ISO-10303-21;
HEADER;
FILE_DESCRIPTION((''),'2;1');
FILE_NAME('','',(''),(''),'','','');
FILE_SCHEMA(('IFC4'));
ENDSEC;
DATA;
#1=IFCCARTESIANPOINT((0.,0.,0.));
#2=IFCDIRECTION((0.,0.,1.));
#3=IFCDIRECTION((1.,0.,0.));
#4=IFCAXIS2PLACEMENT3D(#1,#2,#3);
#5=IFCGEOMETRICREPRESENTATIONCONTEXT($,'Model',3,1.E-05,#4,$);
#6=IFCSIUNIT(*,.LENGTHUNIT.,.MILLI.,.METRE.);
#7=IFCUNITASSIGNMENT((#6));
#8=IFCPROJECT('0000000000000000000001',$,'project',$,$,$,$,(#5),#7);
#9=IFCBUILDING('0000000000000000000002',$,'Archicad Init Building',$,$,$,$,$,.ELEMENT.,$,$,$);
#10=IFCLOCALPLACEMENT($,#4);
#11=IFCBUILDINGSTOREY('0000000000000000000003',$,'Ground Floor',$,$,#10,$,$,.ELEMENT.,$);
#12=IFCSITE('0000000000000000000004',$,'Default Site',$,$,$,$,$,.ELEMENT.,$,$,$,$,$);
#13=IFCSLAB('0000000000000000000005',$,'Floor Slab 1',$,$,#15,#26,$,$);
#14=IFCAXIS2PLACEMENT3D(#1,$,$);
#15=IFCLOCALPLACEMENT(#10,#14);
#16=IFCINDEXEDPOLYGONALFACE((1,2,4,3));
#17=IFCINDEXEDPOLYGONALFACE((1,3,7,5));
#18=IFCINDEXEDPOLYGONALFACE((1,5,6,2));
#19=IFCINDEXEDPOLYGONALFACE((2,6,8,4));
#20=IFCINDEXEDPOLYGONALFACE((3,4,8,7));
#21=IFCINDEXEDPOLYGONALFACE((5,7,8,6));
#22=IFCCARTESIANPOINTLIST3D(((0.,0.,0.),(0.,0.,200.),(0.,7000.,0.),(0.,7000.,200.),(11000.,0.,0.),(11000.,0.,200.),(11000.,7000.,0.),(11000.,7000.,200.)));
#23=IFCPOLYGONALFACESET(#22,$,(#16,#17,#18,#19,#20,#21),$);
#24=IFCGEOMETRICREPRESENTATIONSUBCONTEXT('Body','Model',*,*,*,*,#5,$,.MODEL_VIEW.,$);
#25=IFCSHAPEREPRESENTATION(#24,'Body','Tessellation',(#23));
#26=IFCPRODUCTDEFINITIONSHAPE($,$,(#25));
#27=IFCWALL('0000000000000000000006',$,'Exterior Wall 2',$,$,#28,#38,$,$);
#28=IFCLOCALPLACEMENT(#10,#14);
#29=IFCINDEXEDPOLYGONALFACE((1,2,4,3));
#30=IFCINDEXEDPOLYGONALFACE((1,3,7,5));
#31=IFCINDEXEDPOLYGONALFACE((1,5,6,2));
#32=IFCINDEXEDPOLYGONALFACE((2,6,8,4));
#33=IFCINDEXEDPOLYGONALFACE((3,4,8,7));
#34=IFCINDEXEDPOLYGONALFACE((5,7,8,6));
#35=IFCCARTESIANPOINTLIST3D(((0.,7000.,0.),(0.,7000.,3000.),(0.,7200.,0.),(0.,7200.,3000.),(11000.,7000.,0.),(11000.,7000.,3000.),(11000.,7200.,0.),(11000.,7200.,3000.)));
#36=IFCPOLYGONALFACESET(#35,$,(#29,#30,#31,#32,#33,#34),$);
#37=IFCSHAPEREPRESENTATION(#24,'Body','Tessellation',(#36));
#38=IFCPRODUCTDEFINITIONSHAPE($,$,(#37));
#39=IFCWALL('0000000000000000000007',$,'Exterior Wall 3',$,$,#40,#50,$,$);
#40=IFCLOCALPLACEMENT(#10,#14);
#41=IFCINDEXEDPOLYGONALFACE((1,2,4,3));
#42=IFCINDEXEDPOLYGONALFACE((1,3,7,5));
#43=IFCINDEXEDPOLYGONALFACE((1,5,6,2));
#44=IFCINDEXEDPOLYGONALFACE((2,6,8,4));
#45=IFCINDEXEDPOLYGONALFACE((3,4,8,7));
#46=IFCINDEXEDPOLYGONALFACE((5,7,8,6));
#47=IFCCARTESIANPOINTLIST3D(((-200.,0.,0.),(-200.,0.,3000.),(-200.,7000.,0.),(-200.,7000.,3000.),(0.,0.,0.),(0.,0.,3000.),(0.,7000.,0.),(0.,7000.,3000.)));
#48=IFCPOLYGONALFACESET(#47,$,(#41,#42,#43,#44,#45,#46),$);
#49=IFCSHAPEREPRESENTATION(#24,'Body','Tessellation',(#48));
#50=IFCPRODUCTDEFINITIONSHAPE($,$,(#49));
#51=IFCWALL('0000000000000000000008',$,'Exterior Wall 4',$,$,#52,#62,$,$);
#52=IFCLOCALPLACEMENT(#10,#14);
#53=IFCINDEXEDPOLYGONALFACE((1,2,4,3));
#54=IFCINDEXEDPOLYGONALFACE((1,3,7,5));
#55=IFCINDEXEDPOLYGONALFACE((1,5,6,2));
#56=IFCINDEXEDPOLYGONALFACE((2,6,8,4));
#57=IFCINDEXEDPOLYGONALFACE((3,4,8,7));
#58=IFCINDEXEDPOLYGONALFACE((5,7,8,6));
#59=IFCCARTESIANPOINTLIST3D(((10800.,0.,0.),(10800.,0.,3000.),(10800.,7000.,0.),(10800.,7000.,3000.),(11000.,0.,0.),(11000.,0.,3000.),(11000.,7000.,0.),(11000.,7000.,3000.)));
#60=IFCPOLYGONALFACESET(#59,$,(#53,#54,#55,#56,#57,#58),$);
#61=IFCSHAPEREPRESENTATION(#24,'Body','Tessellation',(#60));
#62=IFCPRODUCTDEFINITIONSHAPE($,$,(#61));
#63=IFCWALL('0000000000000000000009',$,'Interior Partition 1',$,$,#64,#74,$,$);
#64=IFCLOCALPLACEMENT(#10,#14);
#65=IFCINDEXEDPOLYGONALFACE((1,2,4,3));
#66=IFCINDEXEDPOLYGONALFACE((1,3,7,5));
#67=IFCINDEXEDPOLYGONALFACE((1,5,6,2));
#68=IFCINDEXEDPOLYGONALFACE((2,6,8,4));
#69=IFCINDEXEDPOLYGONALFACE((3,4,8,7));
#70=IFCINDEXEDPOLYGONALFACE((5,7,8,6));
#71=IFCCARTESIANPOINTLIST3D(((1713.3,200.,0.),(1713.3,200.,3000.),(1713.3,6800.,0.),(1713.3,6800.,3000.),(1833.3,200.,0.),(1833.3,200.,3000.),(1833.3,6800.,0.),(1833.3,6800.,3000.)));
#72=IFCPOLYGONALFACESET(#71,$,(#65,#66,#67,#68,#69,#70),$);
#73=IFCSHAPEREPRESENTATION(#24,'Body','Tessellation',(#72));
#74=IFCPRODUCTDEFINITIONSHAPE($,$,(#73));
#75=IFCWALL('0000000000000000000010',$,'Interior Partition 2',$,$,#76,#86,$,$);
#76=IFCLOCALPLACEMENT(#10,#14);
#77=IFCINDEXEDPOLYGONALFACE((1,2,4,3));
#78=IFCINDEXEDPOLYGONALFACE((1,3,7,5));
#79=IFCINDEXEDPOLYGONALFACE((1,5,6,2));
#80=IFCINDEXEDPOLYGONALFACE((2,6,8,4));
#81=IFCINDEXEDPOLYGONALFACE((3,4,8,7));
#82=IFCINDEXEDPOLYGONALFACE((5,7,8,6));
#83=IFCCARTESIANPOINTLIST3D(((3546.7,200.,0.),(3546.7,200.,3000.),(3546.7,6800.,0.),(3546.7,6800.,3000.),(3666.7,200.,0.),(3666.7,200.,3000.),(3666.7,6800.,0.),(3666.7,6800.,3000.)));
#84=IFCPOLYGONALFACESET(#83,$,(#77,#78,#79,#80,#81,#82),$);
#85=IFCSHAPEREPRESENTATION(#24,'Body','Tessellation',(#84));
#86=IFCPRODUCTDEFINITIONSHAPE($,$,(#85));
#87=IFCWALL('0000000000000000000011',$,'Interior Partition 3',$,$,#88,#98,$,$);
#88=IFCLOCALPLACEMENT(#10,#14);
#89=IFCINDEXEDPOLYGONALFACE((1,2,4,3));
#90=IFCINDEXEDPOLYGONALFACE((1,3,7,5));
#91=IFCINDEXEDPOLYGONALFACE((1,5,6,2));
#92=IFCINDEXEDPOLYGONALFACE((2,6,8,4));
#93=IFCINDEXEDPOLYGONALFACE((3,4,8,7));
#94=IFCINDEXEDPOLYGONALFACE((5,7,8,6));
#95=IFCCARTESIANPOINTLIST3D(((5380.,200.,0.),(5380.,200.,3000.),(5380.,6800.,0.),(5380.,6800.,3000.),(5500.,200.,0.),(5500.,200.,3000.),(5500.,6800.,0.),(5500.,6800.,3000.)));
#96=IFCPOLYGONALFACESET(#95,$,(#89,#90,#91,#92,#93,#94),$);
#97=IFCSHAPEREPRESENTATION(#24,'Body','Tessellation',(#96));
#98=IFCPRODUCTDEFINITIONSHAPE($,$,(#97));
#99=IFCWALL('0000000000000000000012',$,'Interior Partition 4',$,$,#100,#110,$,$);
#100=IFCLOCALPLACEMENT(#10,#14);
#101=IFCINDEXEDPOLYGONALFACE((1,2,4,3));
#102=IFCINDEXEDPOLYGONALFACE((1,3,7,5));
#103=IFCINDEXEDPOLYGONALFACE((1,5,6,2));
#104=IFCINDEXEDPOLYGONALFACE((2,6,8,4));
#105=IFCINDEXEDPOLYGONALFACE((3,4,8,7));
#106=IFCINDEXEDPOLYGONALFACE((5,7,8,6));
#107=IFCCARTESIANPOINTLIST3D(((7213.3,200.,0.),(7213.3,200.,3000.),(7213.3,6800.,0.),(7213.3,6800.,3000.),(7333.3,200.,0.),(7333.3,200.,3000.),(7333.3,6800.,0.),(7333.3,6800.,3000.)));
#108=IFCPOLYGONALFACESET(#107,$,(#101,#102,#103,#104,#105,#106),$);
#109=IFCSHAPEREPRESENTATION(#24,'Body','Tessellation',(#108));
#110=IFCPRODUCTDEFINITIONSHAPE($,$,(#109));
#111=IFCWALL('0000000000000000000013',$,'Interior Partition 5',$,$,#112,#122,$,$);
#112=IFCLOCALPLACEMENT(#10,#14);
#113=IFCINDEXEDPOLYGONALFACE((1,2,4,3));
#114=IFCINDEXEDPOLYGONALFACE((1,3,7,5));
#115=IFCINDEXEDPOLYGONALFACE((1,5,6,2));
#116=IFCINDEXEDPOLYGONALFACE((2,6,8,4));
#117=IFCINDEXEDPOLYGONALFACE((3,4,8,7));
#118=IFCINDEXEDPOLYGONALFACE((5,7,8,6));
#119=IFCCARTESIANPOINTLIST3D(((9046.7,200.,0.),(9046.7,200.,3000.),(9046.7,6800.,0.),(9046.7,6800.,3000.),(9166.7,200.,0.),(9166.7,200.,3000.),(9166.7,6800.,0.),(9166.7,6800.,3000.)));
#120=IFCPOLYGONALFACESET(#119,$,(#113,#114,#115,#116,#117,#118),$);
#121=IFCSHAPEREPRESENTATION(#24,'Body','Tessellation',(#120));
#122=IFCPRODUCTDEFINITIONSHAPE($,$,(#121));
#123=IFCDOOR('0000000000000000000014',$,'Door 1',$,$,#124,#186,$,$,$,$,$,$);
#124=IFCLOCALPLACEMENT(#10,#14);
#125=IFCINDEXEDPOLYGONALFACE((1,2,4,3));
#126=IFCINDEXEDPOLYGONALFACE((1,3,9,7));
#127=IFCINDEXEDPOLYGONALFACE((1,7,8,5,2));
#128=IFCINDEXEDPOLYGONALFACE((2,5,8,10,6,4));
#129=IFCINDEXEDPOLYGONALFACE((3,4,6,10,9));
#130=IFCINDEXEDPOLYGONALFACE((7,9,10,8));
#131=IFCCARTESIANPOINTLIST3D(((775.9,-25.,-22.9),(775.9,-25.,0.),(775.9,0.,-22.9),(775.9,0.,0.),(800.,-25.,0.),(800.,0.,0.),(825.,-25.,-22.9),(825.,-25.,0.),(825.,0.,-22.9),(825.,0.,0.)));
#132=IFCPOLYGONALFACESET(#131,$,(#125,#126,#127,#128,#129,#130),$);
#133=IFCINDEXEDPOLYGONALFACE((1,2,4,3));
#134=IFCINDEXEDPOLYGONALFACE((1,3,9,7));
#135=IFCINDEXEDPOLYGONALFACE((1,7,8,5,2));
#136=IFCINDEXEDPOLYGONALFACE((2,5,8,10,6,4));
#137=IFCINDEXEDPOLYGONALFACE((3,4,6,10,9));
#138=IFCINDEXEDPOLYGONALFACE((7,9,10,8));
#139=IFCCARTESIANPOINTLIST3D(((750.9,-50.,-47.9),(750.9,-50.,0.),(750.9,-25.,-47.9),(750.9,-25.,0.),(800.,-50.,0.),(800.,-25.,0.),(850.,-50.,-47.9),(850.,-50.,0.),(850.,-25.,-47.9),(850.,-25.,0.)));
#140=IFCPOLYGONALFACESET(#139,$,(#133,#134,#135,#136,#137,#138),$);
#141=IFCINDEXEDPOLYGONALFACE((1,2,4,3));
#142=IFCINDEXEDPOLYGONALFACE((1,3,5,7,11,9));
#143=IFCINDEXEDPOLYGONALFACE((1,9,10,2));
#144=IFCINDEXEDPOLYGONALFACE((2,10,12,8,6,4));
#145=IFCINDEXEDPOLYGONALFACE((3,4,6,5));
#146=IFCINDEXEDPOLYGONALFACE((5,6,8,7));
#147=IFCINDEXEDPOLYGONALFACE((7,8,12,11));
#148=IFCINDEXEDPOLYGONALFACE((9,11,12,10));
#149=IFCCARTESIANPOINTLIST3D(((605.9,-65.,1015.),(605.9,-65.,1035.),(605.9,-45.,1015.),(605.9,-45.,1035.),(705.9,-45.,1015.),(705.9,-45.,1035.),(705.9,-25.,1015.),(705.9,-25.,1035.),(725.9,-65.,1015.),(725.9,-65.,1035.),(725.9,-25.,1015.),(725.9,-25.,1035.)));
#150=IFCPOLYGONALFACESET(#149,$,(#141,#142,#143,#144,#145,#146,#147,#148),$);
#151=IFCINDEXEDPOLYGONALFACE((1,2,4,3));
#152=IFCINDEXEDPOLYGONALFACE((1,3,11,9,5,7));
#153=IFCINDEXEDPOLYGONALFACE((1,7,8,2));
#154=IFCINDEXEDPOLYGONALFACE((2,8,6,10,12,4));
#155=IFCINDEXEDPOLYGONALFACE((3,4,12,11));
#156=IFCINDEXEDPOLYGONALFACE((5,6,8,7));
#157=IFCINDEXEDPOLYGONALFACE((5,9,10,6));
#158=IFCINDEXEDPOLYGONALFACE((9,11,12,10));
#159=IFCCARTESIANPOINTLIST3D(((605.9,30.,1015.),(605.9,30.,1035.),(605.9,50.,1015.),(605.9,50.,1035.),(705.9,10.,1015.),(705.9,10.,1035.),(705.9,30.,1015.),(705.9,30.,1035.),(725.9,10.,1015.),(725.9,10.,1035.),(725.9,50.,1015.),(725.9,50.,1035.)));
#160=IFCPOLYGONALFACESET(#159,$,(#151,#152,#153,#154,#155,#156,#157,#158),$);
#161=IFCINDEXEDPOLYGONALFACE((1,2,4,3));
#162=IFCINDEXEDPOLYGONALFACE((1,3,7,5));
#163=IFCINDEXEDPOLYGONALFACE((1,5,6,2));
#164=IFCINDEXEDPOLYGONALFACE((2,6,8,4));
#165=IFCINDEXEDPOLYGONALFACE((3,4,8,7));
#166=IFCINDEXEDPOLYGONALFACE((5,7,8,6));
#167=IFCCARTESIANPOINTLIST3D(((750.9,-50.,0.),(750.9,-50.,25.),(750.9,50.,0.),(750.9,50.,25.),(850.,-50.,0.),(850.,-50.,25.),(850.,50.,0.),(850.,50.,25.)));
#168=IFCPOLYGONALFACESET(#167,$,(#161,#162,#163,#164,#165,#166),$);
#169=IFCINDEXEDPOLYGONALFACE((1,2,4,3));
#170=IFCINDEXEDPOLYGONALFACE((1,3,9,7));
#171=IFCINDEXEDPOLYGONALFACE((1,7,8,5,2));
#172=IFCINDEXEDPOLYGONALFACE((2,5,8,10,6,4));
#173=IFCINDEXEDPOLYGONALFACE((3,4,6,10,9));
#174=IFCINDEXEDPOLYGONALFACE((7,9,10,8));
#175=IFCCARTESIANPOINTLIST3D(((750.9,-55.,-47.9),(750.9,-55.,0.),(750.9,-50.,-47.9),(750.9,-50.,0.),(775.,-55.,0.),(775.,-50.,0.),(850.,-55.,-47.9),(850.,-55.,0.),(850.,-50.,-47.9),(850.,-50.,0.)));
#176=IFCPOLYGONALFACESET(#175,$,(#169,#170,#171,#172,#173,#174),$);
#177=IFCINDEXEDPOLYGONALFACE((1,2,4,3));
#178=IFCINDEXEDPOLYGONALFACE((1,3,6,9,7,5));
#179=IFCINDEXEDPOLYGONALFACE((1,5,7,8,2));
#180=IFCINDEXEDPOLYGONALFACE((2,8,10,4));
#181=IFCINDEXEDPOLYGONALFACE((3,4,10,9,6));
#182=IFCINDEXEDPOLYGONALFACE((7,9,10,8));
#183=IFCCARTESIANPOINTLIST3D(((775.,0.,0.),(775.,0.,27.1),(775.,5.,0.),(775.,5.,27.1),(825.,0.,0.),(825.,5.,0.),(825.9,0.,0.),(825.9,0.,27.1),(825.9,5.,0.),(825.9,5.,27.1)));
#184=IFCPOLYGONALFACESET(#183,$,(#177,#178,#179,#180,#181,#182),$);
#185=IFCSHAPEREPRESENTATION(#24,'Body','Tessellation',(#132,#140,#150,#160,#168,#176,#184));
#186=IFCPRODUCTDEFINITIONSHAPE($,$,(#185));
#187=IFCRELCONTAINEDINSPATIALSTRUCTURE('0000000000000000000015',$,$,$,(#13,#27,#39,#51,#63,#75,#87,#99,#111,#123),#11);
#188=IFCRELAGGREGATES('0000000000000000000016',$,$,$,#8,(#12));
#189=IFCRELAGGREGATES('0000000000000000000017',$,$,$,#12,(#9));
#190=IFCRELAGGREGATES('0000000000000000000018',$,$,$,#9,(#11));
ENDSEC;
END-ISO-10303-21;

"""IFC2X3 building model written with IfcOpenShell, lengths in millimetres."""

from ifc_helpers import new_model, si_unit, frame, origin_with_axes, place, context, subcontext, project, spatial, polyline, outline, extrude, element, save


model = new_model("IFC2X3")

# Units and contexts
model_context = context("Model", 3, precision=1e-05, world=origin_with_axes())
body_context = subcontext(model_context, "Body", "Model", "MODEL_VIEW")
ifc_project = project(units=[si_unit("LENGTHUNIT", "METRE", prefix="MILLI")], contexts=[model_context])

# Site, building, storey
site = spatial("IfcSite", under=ifc_project, Name="Default Site", CompositionType="ELEMENT")
building = spatial("IfcBuilding", under=site, Name="Archicad Init Building", CompositionType="ELEMENT")
storey_placement = place(None, origin_with_axes())
storey = spatial("IfcBuildingStorey", under=building, at=storey_placement, Name="Ground Floor", CompositionType="ELEMENT")

# Slab
slab_placement = place(storey_placement, origin_with_axes())
element("IfcSlab", 1, at=slab_placement, inside=storey, Name="Floor Slab 1", context=body_context, shape_type="SweptSolid", body=[
    extrude(outline(polyline([(0.0, 0.0), (11000.0, 0.0), (11000.0, 7000.0), (0.0, 7000.0), (0.0, 0.0)])), origin_with_axes(), (0.0, 0.0, 1.0), 200.0),
])

# Walls
wall_placement = place(storey_placement, frame((0.0, 7000.0, 0.0), z_axis=(0.0, 0.0, 1.0), x_axis=(1.0, 0.0, 0.0)))
element("IfcWall", 2, at=wall_placement, inside=storey, Name="Exterior Wall 2", context=body_context, shape_type="SweptSolid", body=[
    extrude(outline(polyline([(0.0, 0.0), (0.0, 200.0), (11000.0, 200.0), (11000.0, 0.0), (0.0, 0.0)])), origin_with_axes(), (0.0, 0.0, 1.0), 3000.0),
])
for number, where, z_axis, x_axis, name in (
    (3, (0.0, 0.0, 0.0), (0.0, 0.0, 1.0), (0.0, 1.0, 0.0), "Exterior Wall 3"),
    (4, (11000.0, 0.0, 0.0), (0.0, 0.0, 1.0), (0.0, 1.0, 0.0), "Exterior Wall 4"),
):
    element("IfcWall", number, at=place(storey_placement, frame(where, z_axis=z_axis, x_axis=x_axis)), inside=storey, Name=name, context=body_context, shape_type="SweptSolid", body=[
        extrude(outline(polyline([(0.0, 0.0), (0.0, 200.0), (7000.0, 200.0), (7000.0, 0.0), (0.0, 0.0)])), origin_with_axes(), (0.0, 0.0, 1.0), 3000.0),
    ])
for number, where, z_axis, x_axis, name in (
    (5, (1833.3, 200.0, 0.0), (0.0, 0.0, 1.0), (0.0, 1.0, 0.0), "Interior Partition 1"),
    (6, (3666.7, 200.0, 0.0), (0.0, 0.0, 1.0), (0.0, 1.0, 0.0), "Interior Partition 2"),
    (7, (5500.0, 200.0, 0.0), (0.0, 0.0, 1.0), (0.0, 1.0, 0.0), "Interior Partition 3"),
    (8, (7333.3, 200.0, 0.0), (0.0, 0.0, 1.0), (0.0, 1.0, 0.0), "Interior Partition 4"),
    (9, (9166.7, 200.0, 0.0), (0.0, 0.0, 1.0), (0.0, 1.0, 0.0), "Interior Partition 5"),
):
    element("IfcWall", number, at=place(storey_placement, frame(where, z_axis=z_axis, x_axis=x_axis)), inside=storey, Name=name, context=body_context, shape_type="SweptSolid", body=[
        extrude(outline(polyline([(0.0, 0.0), (0.0, 120.0), (6600.0, 120.0), (6600.0, 0.0), (0.0, 0.0)])), origin_with_axes(), (0.0, 0.0, 1.0), 3000.0),
    ])

# Door
door_1_placement = place(storey_placement, frame((800.0, -50.0, 0.0), z_axis=(0.0, 0.0, 1.0), x_axis=(1.0, 0.0, 0.0)))
element("IfcDoor", 10, at=door_1_placement, inside=storey, Name="Door 1", context=body_context, shape_type="SweptSolid", body=[
    extrude(outline(polyline([(0.0, 0.0), (0.0, 2.1), (0.9, 2.1), (0.9, 0.0), (-24.1, 0.0), (-24.1, -22.9), (25.0, -22.9), (25.0, 0.0), (0.0, 0.0)])), frame((0.0, 25.0, 0.0), z_axis=(0.0, -1.0, 0.0), x_axis=(1.0, 0.0, 0.0)), (0.0, 0.0, -1.0), 25.0),
    extrude(outline(polyline([(0.0, 0.0), (0.0, 2.1), (0.9, 2.1), (0.9, 0.0), (-49.1, 0.0), (-49.1, -47.9), (50.0, -47.9), (50.0, 0.0), (0.0, 0.0)])), frame((0.0, 0.0, 0.0), z_axis=(0.0, -1.0, 0.0), x_axis=(1.0, 0.0, 0.0)), (0.0, 0.0, -1.0), 25.0),
    extrude(outline(polyline([(0.0, 0.0), (-49.1, 0.0), (-49.1, 35.0), (0.0, 35.0), (0.0, 0.0)])), frame((25.0, 25.0, 25.0), z_axis=(0.0, 0.0, 1.0), x_axis=(1.0, 0.0, 0.0)), (0.0, 0.0, 1.0), -47.9),
    extrude(outline(polyline([(0.0, 0.0), (0.0, -40.0), (-120.0, -40.0), (-120.0, -20.0), (-20.0, -20.0), (-20.0, 0.0), (0.0, 0.0)])), frame((-74.1, 25.0, 1015.0), z_axis=(0.0, 0.0, 1.0), x_axis=(1.0, 0.0, 0.0)), (0.0, 0.0, 1.0), 20.0),
    extrude(outline(polyline([(0.0, 0.0), (0.0, 40.0), (-120.0, 40.0), (-120.0, 20.0), (-20.0, 20.0), (-20.0, 0.0), (0.0, 0.0)])), frame((-74.1, 60.0, 1015.0), z_axis=(0.0, 0.0, 1.0), x_axis=(1.0, 0.0, 0.0)), (0.0, 0.0, 1.0), 20.0),
    extrude(outline(polyline([(0.0, 0.0), (-99.1, 0.0), (-99.1, 100.0), (0.0, 100.0), (0.0, 0.0)])), frame((50.0, 0.0, 0.0), z_axis=(0.0, 0.0, 1.0), x_axis=(1.0, 0.0, 0.0)), (0.0, 0.0, 1.0), 25.0),
    extrude(outline(polyline([(0.0, 0.0), (0.0, 27.1), (50.9, 27.1), (50.9, 0.0), (-24.1, 0.0), (-24.1, -47.9), (75.0, -47.9), (75.0, 0.0), (0.0, 0.0)])), frame((-25.0, -5.0, 0.0), z_axis=(0.0, -1.0, 0.0), x_axis=(1.0, 0.0, 0.0)), (0.0, 0.0, -1.0), 5.0),
    extrude(outline(polyline([(0.0, 0.0), (0.0, 27.1), (50.9, 27.1), (50.9, 0.0), (0.9, 0.0), (0.9, -22.9), (50.0, -22.9), (50.0, 0.0), (0.0, 0.0)])), frame((-25.0, 50.0, 0.0), z_axis=(0.0, -1.0, 0.0), x_axis=(1.0, 0.0, 0.0)), (0.0, 0.0, -1.0), 5.0),
])

save(model, "model.ifc")
